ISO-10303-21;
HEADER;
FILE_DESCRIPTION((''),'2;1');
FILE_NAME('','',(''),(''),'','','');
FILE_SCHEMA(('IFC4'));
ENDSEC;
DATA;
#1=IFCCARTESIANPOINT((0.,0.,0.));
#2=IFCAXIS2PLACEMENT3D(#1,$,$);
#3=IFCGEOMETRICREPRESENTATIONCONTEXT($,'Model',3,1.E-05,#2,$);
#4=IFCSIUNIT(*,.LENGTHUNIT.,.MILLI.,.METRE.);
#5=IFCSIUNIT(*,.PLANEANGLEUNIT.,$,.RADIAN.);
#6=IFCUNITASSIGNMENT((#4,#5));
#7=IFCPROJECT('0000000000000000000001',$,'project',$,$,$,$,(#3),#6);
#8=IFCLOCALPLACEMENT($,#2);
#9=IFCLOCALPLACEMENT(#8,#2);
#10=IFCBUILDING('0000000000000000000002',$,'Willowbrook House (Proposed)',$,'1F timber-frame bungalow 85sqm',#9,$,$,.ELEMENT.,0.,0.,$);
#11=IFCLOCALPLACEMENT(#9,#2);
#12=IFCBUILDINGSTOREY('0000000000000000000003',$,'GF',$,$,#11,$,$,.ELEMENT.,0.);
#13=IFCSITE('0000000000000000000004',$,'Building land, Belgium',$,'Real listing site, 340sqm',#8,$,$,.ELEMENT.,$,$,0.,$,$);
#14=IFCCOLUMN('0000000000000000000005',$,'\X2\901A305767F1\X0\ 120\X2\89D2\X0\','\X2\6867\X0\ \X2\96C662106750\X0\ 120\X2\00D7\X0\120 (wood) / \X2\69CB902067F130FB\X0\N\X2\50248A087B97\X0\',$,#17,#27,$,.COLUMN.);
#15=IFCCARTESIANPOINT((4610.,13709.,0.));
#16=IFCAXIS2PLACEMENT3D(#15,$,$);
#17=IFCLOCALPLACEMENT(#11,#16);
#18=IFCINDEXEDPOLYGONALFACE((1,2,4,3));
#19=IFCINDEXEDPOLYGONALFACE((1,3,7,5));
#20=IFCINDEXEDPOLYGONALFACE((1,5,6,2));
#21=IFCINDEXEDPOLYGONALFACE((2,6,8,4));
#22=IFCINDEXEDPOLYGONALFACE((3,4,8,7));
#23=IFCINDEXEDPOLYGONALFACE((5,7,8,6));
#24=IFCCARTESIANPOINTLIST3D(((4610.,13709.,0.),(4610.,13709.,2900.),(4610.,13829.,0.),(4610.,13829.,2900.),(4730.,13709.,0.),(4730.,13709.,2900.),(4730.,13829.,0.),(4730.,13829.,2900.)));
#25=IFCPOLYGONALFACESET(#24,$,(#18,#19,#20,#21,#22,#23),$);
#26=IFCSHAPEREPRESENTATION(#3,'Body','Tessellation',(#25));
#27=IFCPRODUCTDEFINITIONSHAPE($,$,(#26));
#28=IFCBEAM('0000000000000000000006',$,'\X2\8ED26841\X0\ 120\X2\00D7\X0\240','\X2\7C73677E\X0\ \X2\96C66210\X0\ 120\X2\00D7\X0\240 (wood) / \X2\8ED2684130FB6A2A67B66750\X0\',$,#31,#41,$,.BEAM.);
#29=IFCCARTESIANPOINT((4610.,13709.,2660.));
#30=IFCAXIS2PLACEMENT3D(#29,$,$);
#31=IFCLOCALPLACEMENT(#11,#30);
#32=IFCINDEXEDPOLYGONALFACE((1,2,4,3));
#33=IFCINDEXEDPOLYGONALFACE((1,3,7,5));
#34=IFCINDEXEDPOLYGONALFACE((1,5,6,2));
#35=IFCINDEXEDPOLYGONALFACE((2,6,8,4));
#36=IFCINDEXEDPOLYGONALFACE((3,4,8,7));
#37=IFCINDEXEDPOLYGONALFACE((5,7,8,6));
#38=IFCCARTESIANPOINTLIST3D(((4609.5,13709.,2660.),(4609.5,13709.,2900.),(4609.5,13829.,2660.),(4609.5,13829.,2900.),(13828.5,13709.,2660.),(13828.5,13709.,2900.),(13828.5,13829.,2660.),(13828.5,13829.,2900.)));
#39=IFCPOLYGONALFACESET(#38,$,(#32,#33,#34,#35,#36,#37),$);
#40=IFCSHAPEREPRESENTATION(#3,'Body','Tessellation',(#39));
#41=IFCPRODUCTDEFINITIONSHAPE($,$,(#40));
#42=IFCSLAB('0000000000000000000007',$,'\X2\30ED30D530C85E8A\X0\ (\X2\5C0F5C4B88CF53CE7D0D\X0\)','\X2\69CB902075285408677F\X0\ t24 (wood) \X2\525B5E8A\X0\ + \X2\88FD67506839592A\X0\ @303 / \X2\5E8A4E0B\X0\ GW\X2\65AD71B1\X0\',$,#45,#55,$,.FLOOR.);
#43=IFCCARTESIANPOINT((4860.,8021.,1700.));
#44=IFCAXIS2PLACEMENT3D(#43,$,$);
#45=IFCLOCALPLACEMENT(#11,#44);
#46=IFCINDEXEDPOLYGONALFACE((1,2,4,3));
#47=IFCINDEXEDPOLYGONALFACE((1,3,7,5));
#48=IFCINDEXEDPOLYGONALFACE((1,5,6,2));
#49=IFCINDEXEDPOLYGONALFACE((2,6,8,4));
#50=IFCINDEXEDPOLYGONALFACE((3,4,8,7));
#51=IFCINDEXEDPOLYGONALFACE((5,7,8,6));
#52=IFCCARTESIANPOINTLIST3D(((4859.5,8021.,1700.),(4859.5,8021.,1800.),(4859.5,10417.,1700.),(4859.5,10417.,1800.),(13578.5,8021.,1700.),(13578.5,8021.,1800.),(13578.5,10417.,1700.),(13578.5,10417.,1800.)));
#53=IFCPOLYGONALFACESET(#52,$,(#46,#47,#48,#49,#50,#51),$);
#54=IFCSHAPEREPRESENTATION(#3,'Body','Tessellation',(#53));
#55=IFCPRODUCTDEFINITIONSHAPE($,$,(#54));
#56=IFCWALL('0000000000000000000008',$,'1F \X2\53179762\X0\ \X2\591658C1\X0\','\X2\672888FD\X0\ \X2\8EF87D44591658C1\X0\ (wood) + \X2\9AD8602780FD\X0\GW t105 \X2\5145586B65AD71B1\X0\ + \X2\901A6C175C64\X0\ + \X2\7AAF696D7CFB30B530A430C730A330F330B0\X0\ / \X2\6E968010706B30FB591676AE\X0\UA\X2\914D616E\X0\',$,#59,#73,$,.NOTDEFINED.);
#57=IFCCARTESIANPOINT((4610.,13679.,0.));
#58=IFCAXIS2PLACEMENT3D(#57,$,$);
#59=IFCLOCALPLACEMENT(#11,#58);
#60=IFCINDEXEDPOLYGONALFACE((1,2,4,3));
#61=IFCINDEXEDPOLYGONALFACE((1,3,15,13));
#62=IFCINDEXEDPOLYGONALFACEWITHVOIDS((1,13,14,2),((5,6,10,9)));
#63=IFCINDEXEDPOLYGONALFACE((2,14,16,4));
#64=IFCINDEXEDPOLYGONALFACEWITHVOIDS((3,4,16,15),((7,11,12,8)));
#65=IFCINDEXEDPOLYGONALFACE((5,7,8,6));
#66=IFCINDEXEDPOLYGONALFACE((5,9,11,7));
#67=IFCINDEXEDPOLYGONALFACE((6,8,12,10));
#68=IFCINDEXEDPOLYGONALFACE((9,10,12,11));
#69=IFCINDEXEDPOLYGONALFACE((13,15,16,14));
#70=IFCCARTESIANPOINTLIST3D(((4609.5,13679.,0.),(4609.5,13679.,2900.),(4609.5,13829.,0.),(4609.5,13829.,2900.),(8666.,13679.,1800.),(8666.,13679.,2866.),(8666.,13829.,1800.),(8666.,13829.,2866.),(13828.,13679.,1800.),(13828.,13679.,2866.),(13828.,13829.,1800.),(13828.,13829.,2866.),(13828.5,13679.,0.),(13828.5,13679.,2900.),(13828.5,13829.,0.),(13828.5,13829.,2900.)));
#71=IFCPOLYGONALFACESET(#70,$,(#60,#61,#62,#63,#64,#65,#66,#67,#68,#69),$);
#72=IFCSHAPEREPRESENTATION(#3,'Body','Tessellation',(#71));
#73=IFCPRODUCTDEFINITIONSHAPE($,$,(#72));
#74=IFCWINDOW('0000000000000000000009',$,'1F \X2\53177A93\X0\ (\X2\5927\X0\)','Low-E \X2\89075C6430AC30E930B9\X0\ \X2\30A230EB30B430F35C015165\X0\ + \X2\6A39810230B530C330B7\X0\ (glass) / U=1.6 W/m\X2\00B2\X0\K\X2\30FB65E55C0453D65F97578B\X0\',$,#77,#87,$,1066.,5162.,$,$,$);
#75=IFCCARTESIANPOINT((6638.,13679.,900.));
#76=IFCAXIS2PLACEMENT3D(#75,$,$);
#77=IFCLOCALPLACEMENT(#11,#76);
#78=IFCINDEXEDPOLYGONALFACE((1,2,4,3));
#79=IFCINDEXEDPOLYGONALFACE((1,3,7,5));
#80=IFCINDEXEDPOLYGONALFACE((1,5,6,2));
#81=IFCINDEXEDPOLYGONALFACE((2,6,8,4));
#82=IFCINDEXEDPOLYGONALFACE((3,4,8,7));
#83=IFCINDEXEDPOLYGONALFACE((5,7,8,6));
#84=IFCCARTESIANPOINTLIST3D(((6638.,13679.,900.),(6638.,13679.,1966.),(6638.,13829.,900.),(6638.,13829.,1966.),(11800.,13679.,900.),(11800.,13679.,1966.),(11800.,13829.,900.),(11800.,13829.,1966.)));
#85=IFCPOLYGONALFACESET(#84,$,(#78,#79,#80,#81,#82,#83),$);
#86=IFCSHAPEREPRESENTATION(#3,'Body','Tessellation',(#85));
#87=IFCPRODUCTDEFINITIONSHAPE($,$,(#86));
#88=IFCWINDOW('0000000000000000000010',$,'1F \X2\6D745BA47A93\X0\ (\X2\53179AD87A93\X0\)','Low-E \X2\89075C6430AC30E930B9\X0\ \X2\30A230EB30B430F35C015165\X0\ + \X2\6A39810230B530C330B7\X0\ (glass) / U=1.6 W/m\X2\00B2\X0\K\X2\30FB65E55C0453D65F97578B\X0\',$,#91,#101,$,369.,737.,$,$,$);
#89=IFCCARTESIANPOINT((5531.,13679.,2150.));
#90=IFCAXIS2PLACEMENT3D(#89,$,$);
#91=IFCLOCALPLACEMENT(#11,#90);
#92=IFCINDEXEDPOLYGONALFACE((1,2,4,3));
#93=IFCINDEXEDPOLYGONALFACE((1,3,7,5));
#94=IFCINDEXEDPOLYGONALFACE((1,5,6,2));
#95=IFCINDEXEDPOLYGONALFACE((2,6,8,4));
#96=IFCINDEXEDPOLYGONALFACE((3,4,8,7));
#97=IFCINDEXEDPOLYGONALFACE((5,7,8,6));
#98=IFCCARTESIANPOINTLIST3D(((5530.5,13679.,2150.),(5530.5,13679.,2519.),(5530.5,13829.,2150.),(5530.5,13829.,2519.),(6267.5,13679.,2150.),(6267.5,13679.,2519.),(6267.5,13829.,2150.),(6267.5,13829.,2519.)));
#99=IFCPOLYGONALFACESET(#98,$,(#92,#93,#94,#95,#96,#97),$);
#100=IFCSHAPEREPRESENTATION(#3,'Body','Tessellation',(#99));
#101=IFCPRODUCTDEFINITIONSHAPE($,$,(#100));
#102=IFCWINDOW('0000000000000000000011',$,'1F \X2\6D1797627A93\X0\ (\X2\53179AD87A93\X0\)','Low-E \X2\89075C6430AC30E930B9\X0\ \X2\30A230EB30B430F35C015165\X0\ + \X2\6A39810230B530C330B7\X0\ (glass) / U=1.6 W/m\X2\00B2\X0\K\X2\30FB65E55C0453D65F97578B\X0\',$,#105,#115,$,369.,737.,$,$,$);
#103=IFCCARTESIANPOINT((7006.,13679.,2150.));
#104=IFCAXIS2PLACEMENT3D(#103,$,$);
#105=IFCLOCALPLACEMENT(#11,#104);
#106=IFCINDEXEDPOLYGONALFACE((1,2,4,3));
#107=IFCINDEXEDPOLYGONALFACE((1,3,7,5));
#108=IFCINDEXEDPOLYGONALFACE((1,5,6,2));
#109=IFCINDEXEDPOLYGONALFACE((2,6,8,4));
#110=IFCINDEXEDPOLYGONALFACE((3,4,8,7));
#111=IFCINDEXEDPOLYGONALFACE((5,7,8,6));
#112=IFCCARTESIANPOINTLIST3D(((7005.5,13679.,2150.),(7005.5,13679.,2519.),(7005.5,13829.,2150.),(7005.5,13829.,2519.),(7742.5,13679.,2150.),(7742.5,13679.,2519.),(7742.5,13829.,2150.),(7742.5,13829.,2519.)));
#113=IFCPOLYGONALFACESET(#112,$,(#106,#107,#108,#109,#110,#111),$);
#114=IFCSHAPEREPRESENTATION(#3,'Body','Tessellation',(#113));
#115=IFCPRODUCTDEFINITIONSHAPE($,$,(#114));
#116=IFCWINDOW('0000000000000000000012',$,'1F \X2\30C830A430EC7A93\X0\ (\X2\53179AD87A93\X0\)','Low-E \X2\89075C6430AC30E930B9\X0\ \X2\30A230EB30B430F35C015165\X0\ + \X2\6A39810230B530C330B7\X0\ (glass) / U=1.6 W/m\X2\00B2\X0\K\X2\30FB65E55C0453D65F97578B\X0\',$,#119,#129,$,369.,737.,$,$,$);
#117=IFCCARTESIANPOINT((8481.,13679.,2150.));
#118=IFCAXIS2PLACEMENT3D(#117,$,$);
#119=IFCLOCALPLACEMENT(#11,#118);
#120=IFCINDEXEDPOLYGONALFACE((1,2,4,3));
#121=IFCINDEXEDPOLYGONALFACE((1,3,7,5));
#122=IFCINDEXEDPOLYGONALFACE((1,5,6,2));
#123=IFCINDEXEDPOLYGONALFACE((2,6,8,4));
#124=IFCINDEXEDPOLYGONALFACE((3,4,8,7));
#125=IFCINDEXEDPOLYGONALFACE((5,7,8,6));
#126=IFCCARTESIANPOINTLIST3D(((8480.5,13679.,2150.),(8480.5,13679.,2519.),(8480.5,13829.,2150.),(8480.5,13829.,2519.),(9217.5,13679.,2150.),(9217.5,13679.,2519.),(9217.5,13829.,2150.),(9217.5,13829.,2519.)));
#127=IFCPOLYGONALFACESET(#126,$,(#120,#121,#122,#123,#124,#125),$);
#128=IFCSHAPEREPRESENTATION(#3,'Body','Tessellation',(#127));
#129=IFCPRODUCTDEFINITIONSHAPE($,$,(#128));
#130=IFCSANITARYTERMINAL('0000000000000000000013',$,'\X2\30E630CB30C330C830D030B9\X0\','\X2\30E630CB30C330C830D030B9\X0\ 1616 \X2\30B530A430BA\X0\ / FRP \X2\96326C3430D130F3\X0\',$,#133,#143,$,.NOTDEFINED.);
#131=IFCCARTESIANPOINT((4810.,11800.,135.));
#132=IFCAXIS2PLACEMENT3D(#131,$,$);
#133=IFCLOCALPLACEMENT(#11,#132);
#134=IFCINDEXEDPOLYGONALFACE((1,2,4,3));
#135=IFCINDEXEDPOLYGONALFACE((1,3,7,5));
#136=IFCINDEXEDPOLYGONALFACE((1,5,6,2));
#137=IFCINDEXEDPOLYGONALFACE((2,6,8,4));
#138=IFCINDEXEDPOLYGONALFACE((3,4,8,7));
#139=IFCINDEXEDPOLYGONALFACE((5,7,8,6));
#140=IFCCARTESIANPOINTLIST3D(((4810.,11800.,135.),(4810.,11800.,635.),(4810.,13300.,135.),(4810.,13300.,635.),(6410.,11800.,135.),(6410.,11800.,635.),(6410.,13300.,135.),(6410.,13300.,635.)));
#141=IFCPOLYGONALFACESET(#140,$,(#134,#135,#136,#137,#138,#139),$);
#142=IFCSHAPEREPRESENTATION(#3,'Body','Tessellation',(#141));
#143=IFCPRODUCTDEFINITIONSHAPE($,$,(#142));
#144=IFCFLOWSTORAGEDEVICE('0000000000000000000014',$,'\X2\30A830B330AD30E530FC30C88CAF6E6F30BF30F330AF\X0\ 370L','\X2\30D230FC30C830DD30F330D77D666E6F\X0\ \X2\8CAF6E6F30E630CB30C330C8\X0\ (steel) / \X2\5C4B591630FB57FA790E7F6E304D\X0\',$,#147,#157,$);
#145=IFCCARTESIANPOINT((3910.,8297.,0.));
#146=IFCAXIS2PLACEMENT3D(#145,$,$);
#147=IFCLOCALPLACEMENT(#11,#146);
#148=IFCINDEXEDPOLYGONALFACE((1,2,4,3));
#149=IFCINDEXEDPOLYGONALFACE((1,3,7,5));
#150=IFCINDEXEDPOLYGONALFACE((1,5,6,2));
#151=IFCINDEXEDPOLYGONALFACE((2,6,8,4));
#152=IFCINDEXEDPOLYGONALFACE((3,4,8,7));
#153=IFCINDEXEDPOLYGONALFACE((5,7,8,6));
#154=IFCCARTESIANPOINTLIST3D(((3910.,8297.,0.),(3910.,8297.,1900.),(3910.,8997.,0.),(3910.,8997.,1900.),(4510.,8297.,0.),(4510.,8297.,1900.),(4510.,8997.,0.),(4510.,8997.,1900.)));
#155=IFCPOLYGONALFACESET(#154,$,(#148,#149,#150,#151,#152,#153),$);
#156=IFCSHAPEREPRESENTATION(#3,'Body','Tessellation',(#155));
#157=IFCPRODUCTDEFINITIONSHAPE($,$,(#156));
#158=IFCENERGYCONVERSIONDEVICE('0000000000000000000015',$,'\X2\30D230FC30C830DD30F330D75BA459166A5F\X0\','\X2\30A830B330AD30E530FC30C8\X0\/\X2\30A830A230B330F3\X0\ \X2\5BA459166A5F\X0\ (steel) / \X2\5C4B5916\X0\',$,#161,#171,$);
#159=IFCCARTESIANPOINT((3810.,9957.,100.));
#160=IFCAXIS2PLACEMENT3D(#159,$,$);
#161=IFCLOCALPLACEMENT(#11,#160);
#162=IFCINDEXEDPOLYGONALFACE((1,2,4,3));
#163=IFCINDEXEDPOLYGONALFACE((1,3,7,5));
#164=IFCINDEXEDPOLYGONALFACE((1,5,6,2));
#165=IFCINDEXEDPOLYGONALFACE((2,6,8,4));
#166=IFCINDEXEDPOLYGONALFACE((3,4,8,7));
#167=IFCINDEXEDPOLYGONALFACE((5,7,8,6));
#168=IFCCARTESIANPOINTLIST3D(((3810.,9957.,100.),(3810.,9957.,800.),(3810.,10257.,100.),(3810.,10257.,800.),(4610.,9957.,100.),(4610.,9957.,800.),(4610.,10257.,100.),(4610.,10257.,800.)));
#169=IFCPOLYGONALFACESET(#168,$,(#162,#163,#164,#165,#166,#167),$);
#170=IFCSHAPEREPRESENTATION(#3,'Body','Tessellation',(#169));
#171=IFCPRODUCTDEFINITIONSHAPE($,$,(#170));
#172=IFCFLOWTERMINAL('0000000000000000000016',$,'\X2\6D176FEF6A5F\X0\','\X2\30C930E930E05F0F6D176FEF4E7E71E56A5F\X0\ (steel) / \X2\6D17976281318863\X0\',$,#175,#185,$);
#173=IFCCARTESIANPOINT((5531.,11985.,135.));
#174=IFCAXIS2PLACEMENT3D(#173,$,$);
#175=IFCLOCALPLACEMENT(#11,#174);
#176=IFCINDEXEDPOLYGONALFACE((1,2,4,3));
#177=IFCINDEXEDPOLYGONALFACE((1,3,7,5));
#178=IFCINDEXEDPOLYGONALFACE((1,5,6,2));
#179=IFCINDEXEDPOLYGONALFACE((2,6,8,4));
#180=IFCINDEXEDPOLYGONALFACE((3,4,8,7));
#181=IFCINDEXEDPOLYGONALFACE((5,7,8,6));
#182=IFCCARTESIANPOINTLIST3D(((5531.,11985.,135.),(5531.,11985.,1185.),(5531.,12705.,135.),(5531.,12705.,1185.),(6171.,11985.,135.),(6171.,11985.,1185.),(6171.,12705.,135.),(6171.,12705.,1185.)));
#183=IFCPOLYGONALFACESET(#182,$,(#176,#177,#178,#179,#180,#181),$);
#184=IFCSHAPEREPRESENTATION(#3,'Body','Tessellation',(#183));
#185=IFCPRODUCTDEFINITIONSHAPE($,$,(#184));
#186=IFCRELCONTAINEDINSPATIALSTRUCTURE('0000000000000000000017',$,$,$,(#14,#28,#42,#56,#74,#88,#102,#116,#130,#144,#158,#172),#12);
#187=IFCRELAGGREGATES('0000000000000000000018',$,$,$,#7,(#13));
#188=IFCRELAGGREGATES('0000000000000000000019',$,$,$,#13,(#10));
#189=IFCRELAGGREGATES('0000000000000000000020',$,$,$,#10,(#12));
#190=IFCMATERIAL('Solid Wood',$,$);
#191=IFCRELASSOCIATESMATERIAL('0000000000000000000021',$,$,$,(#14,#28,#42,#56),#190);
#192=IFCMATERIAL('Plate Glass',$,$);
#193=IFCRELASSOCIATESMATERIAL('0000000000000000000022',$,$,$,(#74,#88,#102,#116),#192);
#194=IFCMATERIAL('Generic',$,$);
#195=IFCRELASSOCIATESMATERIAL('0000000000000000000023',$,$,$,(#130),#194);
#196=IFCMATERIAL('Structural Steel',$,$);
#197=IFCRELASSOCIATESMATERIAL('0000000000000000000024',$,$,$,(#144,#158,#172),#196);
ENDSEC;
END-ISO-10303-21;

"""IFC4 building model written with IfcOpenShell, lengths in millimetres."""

from ifc_helpers import new_model, si_unit, frame, frame_2d, origin, place, context, project, spatial, rectangle, extrude, material, element, fill, save


model = new_model("IFC4")

# Units and contexts
model_context = context("Model", 3, precision=1e-05, world=origin())
ifc_project = project(units=[si_unit("LENGTHUNIT", "METRE", prefix="MILLI"), si_unit("PLANEANGLEUNIT", "RADIAN")], contexts=[model_context])

# Site, building, storey
site_placement = place(None, origin())
site = spatial("IfcSite", under=ifc_project, at=site_placement, Name="Building land, Belgium", ObjectType="Real listing site, 340sqm", CompositionType="ELEMENT", RefElevation=0.0)
building_placement = place(site_placement, origin())
building = spatial("IfcBuilding", under=site, at=building_placement, Name="Willowbrook House (Proposed)", ObjectType="1F timber-frame bungalow 85sqm", CompositionType="ELEMENT", ElevationOfRefHeight=0.0, ElevationOfTerrain=0.0)
storey_placement = place(building_placement, origin())
storey = spatial("IfcBuildingStorey", under=building, at=storey_placement, Name="GF", CompositionType="ELEMENT", Elevation=0.0)

# Column
ifc_material_1 = material(Name="Solid Wood")
column_1_placement = place(storey_placement, frame((4610.0, 13709.0, 0.0)))
element("IfcColumn", 1, at=column_1_placement, inside=storey, material=ifc_material_1, Name="通し柱 120角", Description="桧 集成材 120×120 (wood) / 構造柱・N値計算", PredefinedType="COLUMN", context=model_context, shape_type="SweptSolid", body=[
    extrude(rectangle(XDim=120.0, YDim=120.0, at=frame_2d((60.0, 60.0))), frame((4610.0, 13709.0, 0.0)), (0.0, 0.0, 1.0), 2900.0),
])

# Beam
beam_1_placement = place(storey_placement, frame((4610.0, 13709.0, 2660.0)))
element("IfcBeam", 2, at=beam_1_placement, inside=storey, material=ifc_material_1, Name="軒桁 120×240", Description="米松 集成 120×240 (wood) / 軒桁・横架材", PredefinedType="BEAM", context=model_context, shape_type="SweptSolid", body=[
    extrude(rectangle(XDim=9219.0, YDim=120.0, at=frame_2d((4609.0, 60.0))), frame((4610.0, 13709.0, 2660.0)), (0.0, 0.0, 1.0), 240.0),
])

# Slab
slab_placement = place(storey_placement, frame((4860.0, 8021.0, 1700.0)))
element("IfcSlab", 3, at=slab_placement, inside=storey, material=ifc_material_1, Name="ロフト床 (小屋裏収納)", Description="構造用合板 t24 (wood) 剛床 + 製材根太 @303 / 床下 GW断熱", PredefinedType="FLOOR", context=model_context, shape_type="SweptSolid", body=[
    extrude(rectangle(XDim=8719.0, YDim=2396.0, at=frame_2d((4359.0, 1198.0))), frame((4860.0, 8021.0, 1700.0)), (0.0, 0.0, 1.0), 100.0),
])

# Wall, openings, windows
wall_1_placement = place(storey_placement, frame((4610.0, 13679.0, 0.0)))
wall_1 = element("IfcWall", 4, at=wall_1_placement, inside=storey, material=ifc_material_1, Name="1F 北面 外壁", Description="木製 軸組外壁 (wood) + 高性能GW t105 充填断熱 + 通気層 + 窯業系サイディング / 準耐火・外皮UA配慮", PredefinedType="NOTDEFINED", context=model_context, shape_type="SweptSolid", body=[
    extrude(rectangle(XDim=9219.0, YDim=150.0, at=frame_2d((4609.0, 75.0))), frame((4610.0, 13679.0, 0.0)), (0.0, 0.0, 1.0), 2900.0),
])
opening_1_placement = place(storey_placement, frame((6638.0, 13679.0, 900.0)))
opening_1 = element("IfcOpeningElement", 5, at=opening_1_placement, cuts=wall_1, PredefinedType="NOTDEFINED", context=model_context, shape_type="SweptSolid", body=[
    extrude(rectangle(XDim=5162.0, YDim=150.0, at=frame_2d((2581.0, 75.0))), frame((6638.0, 13679.0, 900.0)), (0.0, 0.0, 1.0), 1066.0),
])
opening_2_placement = place(storey_placement, frame((5531.0, 13679.0, 2150.0)))
opening_2 = element("IfcOpeningElement", 6, at=opening_2_placement, cuts=wall_1, PredefinedType="NOTDEFINED", context=model_context, shape_type="SweptSolid", body=[
    extrude(rectangle(XDim=737.0, YDim=150.0, at=frame_2d((368.0, 75.0))), frame((5531.0, 13679.0, 2150.0)), (0.0, 0.0, 1.0), 369.0),
])
opening_3_placement = place(storey_placement, frame((7006.0, 13679.0, 2150.0)))
opening_3 = element("IfcOpeningElement", 7, at=opening_3_placement, cuts=wall_1, PredefinedType="NOTDEFINED", context=model_context, shape_type="SweptSolid", body=[
    extrude(rectangle(XDim=737.0, YDim=150.0, at=frame_2d((368.0, 75.0))), frame((7006.0, 13679.0, 2150.0)), (0.0, 0.0, 1.0), 369.0),
])
opening_4_placement = place(storey_placement, frame((8481.0, 13679.0, 2150.0)))
opening_4 = element("IfcOpeningElement", 8, at=opening_4_placement, cuts=wall_1, PredefinedType="NOTDEFINED", context=model_context, shape_type="SweptSolid", body=[
    extrude(rectangle(XDim=737.0, YDim=150.0, at=frame_2d((368.0, 75.0))), frame((8481.0, 13679.0, 2150.0)), (0.0, 0.0, 1.0), 369.0),
])
ifc_material_2 = material(Name="Plate Glass")
window_1_placement = place(storey_placement, frame((6638.0, 13679.0, 900.0)))
window_1 = element("IfcWindow", 9, at=window_1_placement, inside=storey, material=ifc_material_2, Name="1F 北窓 (大)", Description="Low-E 複層ガラス アルゴン封入 + 樹脂サッシ (glass) / U=1.6 W/m²K・日射取得型", OverallHeight=1066.0, OverallWidth=5162.0, context=model_context, shape_type="SweptSolid", body=[
    extrude(rectangle(XDim=5162.0, YDim=150.0, at=frame_2d((2581.0, 75.0))), frame((6638.0, 13679.0, 900.0)), (0.0, 0.0, 1.0), 1066.0),
])
fill(opening_1, window_1)
window_2_placement = place(storey_placement, frame((5531.0, 13679.0, 2150.0)))
window_2 = element("IfcWindow", 10, at=window_2_placement, inside=storey, material=ifc_material_2, Name="1F 浴室窓 (北高窓)", Description="Low-E 複層ガラス アルゴン封入 + 樹脂サッシ (glass) / U=1.6 W/m²K・日射取得型", OverallHeight=369.0, OverallWidth=737.0, context=model_context, shape_type="SweptSolid", body=[
    extrude(rectangle(XDim=737.0, YDim=150.0, at=frame_2d((368.0, 75.0))), frame((5531.0, 13679.0, 2150.0)), (0.0, 0.0, 1.0), 369.0),
])
fill(opening_2, window_2)
window_3_placement = place(storey_placement, frame((7006.0, 13679.0, 2150.0)))
window_3 = element("IfcWindow", 11, at=window_3_placement, inside=storey, material=ifc_material_2, Name="1F 洗面窓 (北高窓)", Description="Low-E 複層ガラス アルゴン封入 + 樹脂サッシ (glass) / U=1.6 W/m²K・日射取得型", OverallHeight=369.0, OverallWidth=737.0, context=model_context, shape_type="SweptSolid", body=[
    extrude(rectangle(XDim=737.0, YDim=150.0, at=frame_2d((368.0, 75.0))), frame((7006.0, 13679.0, 2150.0)), (0.0, 0.0, 1.0), 369.0),
])
fill(opening_3, window_3)
window_4_placement = place(storey_placement, frame((8481.0, 13679.0, 2150.0)))
window_4 = element("IfcWindow", 12, at=window_4_placement, inside=storey, material=ifc_material_2, Name="1F トイレ窓 (北高窓)", Description="Low-E 複層ガラス アルゴン封入 + 樹脂サッシ (glass) / U=1.6 W/m²K・日射取得型", OverallHeight=369.0, OverallWidth=737.0, context=model_context, shape_type="SweptSolid", body=[
    extrude(rectangle(XDim=737.0, YDim=150.0, at=frame_2d((368.0, 75.0))), frame((8481.0, 13679.0, 2150.0)), (0.0, 0.0, 1.0), 369.0),
])
fill(opening_4, window_4)

# Shared definitions
ifc_material_3 = material(Name="Structural Steel")

# Sanitary terminal
ifc_material_4 = material(Name="Generic")
sanitary_terminal_placement = place(storey_placement, frame((4810.0, 11800.0, 135.0)))
element("IfcSanitaryTerminal", 13, at=sanitary_terminal_placement, inside=storey, material=ifc_material_4, Name="ユニットバス", Description="ユニットバス 1616 サイズ / FRP 防水パン", PredefinedType="NOTDEFINED", context=model_context, shape_type="SweptSolid", body=[
    extrude(rectangle(XDim=1600.0, YDim=1500.0, at=frame_2d((800.0, 750.0))), frame((4810.0, 11800.0, 135.0)), (0.0, 0.0, 1.0), 500.0),
])

# Flow storage device
flow_storage_device_placement = place(storey_placement, frame((3910.0, 8297.0, 0.0)))
element("IfcFlowStorageDevice", 14, at=flow_storage_device_placement, inside=storey, material=ifc_material_3, Name="エコキュート貯湯タンク 370L", Description="ヒートポンプ給湯 貯湯ユニット (steel) / 屋外・基礎置き", context=model_context, shape_type="SweptSolid", body=[
    extrude(rectangle(XDim=600.0, YDim=700.0, at=frame_2d((300.0, 350.0))), frame((3910.0, 8297.0, 0.0)), (0.0, 0.0, 1.0), 1900.0),
])

# Energy conversion device
energy_conversion_device_placement = place(storey_placement, frame((3810.0, 9957.0, 100.0)))
element("IfcEnergyConversionDevice", 15, at=energy_conversion_device_placement, inside=storey, material=ifc_material_3, Name="ヒートポンプ室外機", Description="エコキュート/エアコン 室外機 (steel) / 屋外", context=model_context, shape_type="SweptSolid", body=[
    extrude(rectangle(XDim=800.0, YDim=300.0, at=frame_2d((400.0, 150.0))), frame((3810.0, 9957.0, 100.0)), (0.0, 0.0, 1.0), 700.0),
])

# Flow terminal
flow_terminal_placement = place(storey_placement, frame((5531.0, 11985.0, 135.0)))
element("IfcFlowTerminal", 16, at=flow_terminal_placement, inside=storey, material=ifc_material_3, Name="洗濯機", Description="ドラム式洗濯乾燥機 (steel) / 洗面脱衣", context=model_context, shape_type="SweptSolid", body=[
    extrude(rectangle(XDim=640.0, YDim=720.0, at=frame_2d((320.0, 360.0))), frame((5531.0, 11985.0, 135.0)), (0.0, 0.0, 1.0), 1050.0),
])

save(model, "model.ifc")
